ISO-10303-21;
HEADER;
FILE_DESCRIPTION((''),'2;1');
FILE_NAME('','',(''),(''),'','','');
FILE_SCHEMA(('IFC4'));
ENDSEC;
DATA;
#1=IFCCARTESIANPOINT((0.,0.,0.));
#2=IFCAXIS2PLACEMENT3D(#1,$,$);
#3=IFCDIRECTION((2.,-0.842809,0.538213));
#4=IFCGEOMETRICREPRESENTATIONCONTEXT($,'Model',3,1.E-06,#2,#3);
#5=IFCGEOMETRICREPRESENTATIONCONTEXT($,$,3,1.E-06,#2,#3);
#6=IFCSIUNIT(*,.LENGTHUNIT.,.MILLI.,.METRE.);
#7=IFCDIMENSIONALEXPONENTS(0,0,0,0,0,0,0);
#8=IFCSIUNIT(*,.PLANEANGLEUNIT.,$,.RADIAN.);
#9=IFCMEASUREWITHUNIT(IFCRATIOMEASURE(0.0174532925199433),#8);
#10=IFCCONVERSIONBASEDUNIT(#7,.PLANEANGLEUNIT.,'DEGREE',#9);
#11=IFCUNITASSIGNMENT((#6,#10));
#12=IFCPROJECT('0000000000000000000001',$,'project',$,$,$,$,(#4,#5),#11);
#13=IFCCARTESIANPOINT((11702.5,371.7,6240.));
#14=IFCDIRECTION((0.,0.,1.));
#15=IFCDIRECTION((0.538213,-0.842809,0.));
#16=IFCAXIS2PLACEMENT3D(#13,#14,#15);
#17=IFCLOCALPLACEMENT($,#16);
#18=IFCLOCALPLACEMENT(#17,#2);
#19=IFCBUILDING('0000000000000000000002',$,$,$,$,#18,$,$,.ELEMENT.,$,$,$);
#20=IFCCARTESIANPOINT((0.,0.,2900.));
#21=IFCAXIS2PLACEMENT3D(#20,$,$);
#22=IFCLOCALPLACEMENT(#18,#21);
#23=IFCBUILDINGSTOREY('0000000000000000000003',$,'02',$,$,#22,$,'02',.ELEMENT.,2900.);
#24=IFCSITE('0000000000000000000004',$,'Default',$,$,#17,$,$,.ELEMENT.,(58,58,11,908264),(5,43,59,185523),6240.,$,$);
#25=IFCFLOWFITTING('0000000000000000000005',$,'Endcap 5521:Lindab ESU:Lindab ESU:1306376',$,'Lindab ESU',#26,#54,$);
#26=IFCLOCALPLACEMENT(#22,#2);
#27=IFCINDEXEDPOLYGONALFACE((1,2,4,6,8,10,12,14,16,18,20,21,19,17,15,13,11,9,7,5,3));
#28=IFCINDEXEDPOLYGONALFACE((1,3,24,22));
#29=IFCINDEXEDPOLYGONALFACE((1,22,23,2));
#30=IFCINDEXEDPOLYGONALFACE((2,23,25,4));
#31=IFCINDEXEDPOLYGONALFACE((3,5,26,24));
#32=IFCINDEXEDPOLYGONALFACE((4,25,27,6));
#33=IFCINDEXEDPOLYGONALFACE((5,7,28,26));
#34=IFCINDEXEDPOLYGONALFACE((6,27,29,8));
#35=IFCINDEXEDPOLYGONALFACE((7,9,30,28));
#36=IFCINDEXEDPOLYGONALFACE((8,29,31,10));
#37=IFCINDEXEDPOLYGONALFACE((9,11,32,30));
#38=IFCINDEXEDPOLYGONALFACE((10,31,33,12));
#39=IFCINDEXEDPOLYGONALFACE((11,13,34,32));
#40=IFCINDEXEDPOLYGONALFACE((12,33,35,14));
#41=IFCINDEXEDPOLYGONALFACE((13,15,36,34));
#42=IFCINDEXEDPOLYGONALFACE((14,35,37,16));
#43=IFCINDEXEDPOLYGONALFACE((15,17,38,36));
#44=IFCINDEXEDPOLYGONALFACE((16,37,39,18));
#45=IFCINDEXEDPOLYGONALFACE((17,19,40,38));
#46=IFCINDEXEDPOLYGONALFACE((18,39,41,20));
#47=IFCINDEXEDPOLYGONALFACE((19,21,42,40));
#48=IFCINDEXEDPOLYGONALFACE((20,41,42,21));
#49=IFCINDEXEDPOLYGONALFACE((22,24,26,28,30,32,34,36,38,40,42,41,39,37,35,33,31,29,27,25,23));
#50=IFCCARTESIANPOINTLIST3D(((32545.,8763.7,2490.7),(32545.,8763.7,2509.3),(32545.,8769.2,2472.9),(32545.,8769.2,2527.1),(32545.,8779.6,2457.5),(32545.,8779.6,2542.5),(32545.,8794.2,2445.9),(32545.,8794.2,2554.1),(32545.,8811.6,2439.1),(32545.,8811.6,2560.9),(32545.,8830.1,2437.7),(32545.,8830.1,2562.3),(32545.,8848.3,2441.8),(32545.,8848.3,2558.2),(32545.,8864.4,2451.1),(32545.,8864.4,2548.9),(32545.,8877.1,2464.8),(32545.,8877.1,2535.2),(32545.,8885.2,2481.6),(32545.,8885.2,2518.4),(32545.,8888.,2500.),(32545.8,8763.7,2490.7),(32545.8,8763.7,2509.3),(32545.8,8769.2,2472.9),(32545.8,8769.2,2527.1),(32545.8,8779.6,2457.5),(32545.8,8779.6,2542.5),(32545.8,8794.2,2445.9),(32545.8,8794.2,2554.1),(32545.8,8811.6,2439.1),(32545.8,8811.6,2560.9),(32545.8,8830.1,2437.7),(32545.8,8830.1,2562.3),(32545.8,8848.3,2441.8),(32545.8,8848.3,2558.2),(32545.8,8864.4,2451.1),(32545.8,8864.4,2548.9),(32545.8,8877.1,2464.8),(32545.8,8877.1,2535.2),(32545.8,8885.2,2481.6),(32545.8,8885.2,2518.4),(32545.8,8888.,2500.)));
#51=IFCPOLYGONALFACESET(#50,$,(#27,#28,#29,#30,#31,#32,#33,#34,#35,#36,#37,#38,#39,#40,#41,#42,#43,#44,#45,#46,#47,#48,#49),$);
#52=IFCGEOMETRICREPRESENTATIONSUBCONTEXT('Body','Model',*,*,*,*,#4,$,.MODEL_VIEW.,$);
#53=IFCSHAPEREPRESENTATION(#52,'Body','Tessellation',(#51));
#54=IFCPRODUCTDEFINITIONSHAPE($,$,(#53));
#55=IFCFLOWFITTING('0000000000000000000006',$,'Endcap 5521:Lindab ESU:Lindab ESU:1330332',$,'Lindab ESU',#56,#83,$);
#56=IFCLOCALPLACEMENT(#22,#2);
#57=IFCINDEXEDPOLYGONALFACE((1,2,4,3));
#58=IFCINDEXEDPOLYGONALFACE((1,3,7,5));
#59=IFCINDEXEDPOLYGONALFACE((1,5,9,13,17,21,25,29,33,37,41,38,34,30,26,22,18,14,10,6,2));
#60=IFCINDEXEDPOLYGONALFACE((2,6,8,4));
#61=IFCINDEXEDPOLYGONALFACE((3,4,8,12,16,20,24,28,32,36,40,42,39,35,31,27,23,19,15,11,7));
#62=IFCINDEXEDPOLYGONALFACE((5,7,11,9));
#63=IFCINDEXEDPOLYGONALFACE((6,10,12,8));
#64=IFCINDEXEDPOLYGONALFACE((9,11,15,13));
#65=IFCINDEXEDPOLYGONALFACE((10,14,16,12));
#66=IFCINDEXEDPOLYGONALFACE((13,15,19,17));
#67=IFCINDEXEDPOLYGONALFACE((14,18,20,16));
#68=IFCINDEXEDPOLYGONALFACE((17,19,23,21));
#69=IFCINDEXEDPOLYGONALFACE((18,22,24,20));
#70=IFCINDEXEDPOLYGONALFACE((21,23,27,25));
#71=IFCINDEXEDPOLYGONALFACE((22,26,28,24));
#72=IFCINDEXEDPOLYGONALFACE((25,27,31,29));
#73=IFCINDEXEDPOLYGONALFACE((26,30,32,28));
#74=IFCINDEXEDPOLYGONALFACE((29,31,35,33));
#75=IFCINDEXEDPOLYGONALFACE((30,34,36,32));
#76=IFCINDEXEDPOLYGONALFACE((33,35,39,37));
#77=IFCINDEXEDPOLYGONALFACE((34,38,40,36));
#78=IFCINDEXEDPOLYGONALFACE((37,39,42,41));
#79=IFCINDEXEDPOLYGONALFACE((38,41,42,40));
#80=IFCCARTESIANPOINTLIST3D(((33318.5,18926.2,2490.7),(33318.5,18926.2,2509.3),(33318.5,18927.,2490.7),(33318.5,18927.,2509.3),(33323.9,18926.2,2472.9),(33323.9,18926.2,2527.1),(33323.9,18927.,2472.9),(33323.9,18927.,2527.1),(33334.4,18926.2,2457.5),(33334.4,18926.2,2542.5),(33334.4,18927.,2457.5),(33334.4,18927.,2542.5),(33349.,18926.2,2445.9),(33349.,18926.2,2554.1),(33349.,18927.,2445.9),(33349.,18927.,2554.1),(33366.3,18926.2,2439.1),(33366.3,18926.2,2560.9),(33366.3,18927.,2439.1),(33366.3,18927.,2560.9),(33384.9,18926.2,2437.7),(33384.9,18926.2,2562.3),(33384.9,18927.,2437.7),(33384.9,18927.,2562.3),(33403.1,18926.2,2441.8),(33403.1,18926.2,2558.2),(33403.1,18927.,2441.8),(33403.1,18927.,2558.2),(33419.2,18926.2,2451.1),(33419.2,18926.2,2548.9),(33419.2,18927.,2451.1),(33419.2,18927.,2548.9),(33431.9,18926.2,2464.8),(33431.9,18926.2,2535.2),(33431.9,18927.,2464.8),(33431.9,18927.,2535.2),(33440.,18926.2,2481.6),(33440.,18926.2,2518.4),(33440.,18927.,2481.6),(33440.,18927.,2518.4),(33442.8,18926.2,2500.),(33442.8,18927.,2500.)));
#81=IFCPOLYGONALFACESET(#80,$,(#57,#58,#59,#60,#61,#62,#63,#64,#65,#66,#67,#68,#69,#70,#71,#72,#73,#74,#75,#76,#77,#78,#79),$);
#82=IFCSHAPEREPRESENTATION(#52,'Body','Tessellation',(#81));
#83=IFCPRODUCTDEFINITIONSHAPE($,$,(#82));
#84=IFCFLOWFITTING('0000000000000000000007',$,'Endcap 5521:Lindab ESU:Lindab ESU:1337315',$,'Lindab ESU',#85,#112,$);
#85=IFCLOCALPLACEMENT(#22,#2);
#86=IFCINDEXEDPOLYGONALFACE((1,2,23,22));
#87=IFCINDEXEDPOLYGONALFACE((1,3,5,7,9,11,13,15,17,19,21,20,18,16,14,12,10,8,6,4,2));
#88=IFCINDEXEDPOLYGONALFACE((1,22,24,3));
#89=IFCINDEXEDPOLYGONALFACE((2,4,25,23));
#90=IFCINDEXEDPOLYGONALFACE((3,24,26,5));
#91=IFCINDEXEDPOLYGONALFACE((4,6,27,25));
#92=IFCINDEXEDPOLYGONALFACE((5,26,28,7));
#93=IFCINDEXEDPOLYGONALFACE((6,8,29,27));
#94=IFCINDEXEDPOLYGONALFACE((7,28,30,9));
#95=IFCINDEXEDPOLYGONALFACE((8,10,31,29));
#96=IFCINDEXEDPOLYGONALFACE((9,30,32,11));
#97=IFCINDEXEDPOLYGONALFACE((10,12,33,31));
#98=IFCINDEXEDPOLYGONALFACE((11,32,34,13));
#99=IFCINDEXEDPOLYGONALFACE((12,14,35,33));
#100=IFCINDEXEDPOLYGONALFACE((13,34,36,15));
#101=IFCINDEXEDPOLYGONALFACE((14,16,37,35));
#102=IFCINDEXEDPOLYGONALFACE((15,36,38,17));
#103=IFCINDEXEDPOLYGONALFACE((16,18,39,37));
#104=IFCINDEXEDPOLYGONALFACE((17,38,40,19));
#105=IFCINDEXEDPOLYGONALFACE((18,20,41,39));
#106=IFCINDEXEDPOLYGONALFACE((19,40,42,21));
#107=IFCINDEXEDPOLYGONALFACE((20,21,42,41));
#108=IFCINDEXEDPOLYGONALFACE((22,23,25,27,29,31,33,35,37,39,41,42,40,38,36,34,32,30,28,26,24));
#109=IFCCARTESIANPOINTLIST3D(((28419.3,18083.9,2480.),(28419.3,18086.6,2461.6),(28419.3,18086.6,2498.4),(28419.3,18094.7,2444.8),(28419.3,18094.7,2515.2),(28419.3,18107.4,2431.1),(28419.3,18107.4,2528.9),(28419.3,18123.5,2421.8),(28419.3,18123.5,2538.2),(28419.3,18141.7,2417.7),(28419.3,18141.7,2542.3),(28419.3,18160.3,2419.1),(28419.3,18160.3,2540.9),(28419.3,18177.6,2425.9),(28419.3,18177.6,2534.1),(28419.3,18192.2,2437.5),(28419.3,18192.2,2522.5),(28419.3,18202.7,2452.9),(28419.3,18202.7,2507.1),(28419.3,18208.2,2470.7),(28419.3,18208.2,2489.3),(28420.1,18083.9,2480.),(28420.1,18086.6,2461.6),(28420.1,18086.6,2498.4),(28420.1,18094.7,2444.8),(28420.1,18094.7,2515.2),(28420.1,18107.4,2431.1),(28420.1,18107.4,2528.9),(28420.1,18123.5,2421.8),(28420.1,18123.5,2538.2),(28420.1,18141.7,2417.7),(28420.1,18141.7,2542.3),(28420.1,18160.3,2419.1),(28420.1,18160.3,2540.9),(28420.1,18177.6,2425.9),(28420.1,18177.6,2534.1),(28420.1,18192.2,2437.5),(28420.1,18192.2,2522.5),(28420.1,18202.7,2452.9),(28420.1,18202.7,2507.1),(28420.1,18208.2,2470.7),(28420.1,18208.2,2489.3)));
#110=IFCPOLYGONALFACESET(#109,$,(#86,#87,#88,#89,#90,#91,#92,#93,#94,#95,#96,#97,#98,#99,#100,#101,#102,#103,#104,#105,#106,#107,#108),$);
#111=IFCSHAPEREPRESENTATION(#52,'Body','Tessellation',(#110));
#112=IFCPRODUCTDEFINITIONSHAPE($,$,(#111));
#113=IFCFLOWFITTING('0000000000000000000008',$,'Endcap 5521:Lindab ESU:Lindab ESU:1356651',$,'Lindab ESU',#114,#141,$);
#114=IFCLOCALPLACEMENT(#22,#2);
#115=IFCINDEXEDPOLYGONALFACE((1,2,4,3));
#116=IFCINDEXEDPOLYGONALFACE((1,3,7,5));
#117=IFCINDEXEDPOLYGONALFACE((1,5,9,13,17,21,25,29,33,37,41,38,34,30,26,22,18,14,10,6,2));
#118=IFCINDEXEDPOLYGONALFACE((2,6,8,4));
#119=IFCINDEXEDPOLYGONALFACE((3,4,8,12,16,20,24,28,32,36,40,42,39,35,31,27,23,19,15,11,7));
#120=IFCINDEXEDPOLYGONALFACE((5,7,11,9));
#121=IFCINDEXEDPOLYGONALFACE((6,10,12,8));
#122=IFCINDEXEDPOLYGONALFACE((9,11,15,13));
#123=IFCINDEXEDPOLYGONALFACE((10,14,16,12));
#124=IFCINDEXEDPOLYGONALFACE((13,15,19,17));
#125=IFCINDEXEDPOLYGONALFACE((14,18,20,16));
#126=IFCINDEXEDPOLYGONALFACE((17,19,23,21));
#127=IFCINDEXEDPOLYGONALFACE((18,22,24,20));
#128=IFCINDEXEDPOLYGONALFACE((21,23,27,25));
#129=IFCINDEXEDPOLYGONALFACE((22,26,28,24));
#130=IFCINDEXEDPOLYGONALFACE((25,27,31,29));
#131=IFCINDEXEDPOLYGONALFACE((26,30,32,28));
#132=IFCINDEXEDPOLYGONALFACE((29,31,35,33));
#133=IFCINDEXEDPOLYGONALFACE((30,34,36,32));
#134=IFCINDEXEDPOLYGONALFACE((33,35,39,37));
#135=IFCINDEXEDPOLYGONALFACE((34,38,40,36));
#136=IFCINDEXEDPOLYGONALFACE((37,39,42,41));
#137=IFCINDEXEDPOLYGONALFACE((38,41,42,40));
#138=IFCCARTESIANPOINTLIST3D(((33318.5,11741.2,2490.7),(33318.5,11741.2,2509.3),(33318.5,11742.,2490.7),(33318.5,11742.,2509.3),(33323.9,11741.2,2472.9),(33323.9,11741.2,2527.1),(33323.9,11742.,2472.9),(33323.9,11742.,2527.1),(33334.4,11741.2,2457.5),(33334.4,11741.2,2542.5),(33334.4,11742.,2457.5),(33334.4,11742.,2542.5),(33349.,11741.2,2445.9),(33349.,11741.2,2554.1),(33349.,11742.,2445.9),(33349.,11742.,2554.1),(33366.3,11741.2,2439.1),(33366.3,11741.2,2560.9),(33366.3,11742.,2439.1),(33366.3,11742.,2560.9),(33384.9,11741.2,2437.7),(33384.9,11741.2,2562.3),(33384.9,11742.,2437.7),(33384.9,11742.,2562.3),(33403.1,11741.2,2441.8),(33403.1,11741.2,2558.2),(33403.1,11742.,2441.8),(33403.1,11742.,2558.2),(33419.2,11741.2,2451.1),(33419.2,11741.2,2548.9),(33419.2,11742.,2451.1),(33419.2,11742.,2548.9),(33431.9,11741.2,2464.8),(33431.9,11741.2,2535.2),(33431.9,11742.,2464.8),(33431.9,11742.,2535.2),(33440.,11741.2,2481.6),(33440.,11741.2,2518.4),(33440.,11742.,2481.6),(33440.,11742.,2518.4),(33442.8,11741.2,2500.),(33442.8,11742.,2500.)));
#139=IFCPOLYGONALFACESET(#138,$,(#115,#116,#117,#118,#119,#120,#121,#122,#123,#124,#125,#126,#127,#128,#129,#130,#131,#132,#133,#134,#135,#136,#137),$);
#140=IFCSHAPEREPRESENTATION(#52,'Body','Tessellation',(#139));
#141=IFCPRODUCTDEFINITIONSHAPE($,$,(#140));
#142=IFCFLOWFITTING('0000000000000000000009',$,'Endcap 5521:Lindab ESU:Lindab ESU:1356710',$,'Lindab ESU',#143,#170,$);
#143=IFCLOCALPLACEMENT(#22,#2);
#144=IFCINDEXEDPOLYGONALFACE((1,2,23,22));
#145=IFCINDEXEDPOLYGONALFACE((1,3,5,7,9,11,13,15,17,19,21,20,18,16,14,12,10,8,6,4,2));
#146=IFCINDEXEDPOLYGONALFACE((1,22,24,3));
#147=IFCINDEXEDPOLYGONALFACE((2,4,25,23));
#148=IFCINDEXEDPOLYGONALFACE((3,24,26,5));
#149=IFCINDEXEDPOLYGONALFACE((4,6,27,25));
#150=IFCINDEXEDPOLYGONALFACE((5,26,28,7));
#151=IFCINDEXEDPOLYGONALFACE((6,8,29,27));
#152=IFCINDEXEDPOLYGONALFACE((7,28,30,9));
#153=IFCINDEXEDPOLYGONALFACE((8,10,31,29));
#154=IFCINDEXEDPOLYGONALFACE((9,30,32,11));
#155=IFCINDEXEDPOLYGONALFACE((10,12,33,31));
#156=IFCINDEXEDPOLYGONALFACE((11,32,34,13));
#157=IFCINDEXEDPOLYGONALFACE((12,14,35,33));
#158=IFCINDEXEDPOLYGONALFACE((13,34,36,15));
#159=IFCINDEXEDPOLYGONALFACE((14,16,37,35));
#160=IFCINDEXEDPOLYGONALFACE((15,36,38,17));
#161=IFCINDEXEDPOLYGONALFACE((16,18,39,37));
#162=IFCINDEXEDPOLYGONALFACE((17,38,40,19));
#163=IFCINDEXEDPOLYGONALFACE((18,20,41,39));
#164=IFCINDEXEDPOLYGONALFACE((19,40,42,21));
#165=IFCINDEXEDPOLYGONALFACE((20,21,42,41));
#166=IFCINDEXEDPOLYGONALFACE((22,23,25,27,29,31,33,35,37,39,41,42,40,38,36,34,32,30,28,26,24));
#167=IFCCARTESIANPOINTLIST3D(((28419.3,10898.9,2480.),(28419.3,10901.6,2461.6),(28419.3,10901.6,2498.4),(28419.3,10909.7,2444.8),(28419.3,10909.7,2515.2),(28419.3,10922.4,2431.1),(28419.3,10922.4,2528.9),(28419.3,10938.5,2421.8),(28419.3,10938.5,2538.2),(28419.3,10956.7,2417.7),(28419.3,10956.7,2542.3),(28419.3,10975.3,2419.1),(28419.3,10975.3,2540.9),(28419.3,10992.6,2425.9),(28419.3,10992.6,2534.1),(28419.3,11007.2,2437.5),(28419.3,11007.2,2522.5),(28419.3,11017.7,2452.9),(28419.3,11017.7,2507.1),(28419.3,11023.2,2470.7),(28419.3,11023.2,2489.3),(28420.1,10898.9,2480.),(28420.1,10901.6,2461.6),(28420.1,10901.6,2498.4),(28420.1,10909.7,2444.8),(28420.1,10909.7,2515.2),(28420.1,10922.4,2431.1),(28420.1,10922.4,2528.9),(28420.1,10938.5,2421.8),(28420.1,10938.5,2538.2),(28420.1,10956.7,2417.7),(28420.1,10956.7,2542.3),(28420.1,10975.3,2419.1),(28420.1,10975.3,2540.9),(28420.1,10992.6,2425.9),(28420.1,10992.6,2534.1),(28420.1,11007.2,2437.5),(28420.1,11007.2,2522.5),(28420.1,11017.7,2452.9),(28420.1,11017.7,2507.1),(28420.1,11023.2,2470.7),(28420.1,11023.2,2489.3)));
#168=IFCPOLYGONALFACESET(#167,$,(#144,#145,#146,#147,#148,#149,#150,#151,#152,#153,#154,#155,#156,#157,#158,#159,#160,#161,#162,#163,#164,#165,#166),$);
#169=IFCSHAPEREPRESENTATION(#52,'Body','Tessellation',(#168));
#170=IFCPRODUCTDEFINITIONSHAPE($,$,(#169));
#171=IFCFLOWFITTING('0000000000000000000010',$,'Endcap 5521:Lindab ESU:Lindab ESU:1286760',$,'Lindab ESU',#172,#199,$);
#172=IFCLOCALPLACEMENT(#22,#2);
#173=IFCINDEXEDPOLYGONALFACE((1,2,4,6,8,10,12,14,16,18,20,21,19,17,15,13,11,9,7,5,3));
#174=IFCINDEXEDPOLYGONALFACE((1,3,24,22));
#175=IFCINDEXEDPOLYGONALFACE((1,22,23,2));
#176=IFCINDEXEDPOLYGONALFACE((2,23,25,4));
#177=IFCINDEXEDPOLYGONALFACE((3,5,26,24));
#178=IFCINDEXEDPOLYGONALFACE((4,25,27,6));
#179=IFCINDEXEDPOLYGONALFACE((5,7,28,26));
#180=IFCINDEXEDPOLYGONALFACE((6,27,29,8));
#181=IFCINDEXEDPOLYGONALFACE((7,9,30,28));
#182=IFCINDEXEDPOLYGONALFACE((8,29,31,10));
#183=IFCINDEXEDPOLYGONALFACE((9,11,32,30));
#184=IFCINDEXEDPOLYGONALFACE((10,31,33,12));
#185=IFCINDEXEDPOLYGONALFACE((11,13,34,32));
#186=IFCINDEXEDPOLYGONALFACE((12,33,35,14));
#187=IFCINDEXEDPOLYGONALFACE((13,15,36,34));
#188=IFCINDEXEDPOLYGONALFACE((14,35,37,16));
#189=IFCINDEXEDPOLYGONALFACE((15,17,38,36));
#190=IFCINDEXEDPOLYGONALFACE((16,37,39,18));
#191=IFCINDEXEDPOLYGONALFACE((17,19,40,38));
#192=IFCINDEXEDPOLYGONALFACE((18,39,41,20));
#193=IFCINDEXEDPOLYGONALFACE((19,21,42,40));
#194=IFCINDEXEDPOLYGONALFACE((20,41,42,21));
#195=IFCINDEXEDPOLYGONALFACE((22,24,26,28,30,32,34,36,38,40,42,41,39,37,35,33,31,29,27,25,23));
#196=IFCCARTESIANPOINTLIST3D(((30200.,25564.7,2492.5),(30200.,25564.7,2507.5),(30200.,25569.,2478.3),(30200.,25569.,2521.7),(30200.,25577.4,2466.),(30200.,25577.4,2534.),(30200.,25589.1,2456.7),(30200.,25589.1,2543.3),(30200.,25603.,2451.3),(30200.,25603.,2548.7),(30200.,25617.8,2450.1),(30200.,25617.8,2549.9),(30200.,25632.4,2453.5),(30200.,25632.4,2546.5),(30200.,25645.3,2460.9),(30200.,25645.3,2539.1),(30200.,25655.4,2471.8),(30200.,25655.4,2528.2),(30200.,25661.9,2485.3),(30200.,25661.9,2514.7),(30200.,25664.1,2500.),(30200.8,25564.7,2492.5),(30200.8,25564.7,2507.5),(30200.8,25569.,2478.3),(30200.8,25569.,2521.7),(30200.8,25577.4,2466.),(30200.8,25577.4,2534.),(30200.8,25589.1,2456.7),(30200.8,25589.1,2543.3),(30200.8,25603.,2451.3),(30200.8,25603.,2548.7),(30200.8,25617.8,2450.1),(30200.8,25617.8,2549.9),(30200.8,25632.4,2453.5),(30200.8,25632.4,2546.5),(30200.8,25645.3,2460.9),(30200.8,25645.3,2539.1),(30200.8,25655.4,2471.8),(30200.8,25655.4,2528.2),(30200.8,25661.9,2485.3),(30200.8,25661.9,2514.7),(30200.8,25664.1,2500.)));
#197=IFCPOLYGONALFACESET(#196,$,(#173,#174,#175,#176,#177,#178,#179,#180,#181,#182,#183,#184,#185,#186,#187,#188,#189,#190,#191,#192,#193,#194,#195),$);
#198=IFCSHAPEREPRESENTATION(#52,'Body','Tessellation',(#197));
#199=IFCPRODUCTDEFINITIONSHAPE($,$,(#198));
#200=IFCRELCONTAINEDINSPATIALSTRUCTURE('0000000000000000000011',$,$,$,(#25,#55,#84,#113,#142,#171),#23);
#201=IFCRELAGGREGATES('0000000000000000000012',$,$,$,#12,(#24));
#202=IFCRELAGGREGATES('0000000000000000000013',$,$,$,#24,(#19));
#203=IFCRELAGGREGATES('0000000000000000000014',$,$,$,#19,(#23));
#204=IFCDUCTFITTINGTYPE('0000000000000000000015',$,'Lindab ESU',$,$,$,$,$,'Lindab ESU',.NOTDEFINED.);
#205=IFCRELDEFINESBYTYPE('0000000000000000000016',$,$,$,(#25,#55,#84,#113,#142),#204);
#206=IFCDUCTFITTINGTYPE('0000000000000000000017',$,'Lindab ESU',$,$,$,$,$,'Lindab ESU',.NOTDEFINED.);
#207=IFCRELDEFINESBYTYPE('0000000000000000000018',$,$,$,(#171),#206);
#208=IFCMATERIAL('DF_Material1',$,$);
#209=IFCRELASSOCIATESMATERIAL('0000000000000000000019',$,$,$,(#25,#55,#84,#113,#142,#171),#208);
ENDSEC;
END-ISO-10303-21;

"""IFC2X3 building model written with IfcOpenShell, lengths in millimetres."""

from ifc_helpers import new_model, entity, si_unit, converted_unit, direction, frame, frame_2d, origin, place, context, subcontext, project, spatial, circle, extrude, source, transform, mapped, material, type_object, type_shapes, element, save


model = new_model("IFC2X3")

# Units and contexts
model_context = context("Model", 3, precision=1e-06, world=origin(), true_north=direction((2.0, -0.842809, 0.538213)))
context_of_model = context(None, 3, precision=1e-06, world=origin(), true_north=direction((2.0, -0.842809, 0.538213)))
body_context = subcontext(model_context, "Body", "Model", "MODEL_VIEW")
ifc_project = project(units=[si_unit("LENGTHUNIT", "METRE", prefix="MILLI"), converted_unit("PLANEANGLEUNIT", "DEGREE", entity("IfcRatioMeasure", 0.0174532925199433), si_unit("PLANEANGLEUNIT", "RADIAN"), dimensions=[0, 0, 0, 0, 0, 0, 0])], contexts=[model_context, context_of_model])

# Site, building, storey
site_placement = place(None, frame((11702.5, 371.7, 6240.0), z_axis=(0.0, 0.0, 1.0), x_axis=(0.538213, -0.842809, 0.0)))
site = spatial("IfcSite", under=ifc_project, at=site_placement, Name="Default", CompositionType="ELEMENT", RefLatitude=(58, 58, 11, 908264), RefLongitude=(5, 43, 59, 185523), RefElevation=6240.0)
building_placement = place(site_placement, origin())
building = spatial("IfcBuilding", under=site, at=building_placement, CompositionType="ELEMENT")
storey_placement = place(building_placement, frame((0.0, 0.0, 2900.0)))
storey = spatial("IfcBuildingStorey", under=building, at=storey_placement, Name="02", LongName="02", CompositionType="ELEMENT", Elevation=2900.0)

# Flow fittings
ifc_material = material(Name="DF_Material1")
duct_fitting_type_1 = type_object("IfcDuctFittingType", Name="Lindab ESU", ElementType="Lindab ESU", PredefinedType="NOTDEFINED")
shared_shape_1 = source(origin(), body_context, "Body", "SweptSolid", [
    extrude(circle(Radius=62.5, at=frame_2d((0.0, 0.0), x_axis=(1.0, 0.0))), frame((0.0, 0.0, 0.0), z_axis=(1.0, 0.0, 0.0), x_axis=(0.0, 1.0, 0.0)), (0.0, 0.0, 1.0), 0.8),
])
type_shapes(duct_fitting_type_1, [shared_shape_1])
flow_fitting_1_placement = place(storey_placement, frame((32545.0, 8825.5, 2500.0)))
element("IfcFlowFitting", 1, at=flow_fitting_1_placement, inside=storey, type_object=duct_fitting_type_1, material=ifc_material, Name="Endcap 5521:Lindab ESU:Lindab ESU:1306376", ObjectType="Lindab ESU", context=body_context, shape_type="MappedRepresentation", body=[
    mapped(shared_shape_1, transform((0.0, 0.0, 0.0), scale=1.0)),
])
for number, where, z_axis, x_axis, name in (
    (2, (33380.3, 18927.0, 2500.0), (0.0, 0.0, 1.0), (0.0, -1.0, 0.0), "Endcap 5521:Lindab ESU:Lindab ESU:1330332"),
    (3, (28420.1, 18146.4, 2480.0), (0.0, 0.0, 1.0), (-1.0, 0.0, 0.0), "Endcap 5521:Lindab ESU:Lindab ESU:1337315"),
    (4, (33380.3, 11742.0, 2500.0), (0.0, 0.0, 1.0), (0.0, -1.0, 0.0), "Endcap 5521:Lindab ESU:Lindab ESU:1356651"),
    (5, (28420.1, 10961.4, 2480.0), (0.0, 0.0, 1.0), (-1.0, 0.0, 0.0), "Endcap 5521:Lindab ESU:Lindab ESU:1356710"),
):
    element("IfcFlowFitting", number, at=place(storey_placement, frame(where, z_axis=z_axis, x_axis=x_axis)), inside=storey, type_object=duct_fitting_type_1, material=ifc_material, Name=name, ObjectType="Lindab ESU", context=body_context, shape_type="MappedRepresentation", body=[
        mapped(shared_shape_1, transform((0.0, 0.0, 0.0), scale=1.0)),
    ])
duct_fitting_type_2 = type_object("IfcDuctFittingType", Name="Lindab ESU", ElementType="Lindab ESU", PredefinedType="NOTDEFINED")
shared_shape_2 = source(origin(), body_context, "Body", "SweptSolid", [
    extrude(circle(Radius=50.0, at=frame_2d((0.0, 0.0), x_axis=(1.0, 0.0))), frame((0.0, 0.0, 0.0), z_axis=(1.0, 0.0, 0.0), x_axis=(0.0, 1.0, 0.0)), (0.0, 0.0, 1.0), 0.8),
])
type_shapes(duct_fitting_type_2, [shared_shape_2])
flow_fitting_2_placement = place(storey_placement, frame((30200.0, 25614.1, 2500.0)))
element("IfcFlowFitting", 6, at=flow_fitting_2_placement, inside=storey, type_object=duct_fitting_type_2, material=ifc_material, Name="Endcap 5521:Lindab ESU:Lindab ESU:1286760", ObjectType="Lindab ESU", context=body_context, shape_type="MappedRepresentation", body=[
    mapped(shared_shape_2, transform((0.0, 0.0, 0.0), scale=1.0)),
])

save(model, "model.ifc")
